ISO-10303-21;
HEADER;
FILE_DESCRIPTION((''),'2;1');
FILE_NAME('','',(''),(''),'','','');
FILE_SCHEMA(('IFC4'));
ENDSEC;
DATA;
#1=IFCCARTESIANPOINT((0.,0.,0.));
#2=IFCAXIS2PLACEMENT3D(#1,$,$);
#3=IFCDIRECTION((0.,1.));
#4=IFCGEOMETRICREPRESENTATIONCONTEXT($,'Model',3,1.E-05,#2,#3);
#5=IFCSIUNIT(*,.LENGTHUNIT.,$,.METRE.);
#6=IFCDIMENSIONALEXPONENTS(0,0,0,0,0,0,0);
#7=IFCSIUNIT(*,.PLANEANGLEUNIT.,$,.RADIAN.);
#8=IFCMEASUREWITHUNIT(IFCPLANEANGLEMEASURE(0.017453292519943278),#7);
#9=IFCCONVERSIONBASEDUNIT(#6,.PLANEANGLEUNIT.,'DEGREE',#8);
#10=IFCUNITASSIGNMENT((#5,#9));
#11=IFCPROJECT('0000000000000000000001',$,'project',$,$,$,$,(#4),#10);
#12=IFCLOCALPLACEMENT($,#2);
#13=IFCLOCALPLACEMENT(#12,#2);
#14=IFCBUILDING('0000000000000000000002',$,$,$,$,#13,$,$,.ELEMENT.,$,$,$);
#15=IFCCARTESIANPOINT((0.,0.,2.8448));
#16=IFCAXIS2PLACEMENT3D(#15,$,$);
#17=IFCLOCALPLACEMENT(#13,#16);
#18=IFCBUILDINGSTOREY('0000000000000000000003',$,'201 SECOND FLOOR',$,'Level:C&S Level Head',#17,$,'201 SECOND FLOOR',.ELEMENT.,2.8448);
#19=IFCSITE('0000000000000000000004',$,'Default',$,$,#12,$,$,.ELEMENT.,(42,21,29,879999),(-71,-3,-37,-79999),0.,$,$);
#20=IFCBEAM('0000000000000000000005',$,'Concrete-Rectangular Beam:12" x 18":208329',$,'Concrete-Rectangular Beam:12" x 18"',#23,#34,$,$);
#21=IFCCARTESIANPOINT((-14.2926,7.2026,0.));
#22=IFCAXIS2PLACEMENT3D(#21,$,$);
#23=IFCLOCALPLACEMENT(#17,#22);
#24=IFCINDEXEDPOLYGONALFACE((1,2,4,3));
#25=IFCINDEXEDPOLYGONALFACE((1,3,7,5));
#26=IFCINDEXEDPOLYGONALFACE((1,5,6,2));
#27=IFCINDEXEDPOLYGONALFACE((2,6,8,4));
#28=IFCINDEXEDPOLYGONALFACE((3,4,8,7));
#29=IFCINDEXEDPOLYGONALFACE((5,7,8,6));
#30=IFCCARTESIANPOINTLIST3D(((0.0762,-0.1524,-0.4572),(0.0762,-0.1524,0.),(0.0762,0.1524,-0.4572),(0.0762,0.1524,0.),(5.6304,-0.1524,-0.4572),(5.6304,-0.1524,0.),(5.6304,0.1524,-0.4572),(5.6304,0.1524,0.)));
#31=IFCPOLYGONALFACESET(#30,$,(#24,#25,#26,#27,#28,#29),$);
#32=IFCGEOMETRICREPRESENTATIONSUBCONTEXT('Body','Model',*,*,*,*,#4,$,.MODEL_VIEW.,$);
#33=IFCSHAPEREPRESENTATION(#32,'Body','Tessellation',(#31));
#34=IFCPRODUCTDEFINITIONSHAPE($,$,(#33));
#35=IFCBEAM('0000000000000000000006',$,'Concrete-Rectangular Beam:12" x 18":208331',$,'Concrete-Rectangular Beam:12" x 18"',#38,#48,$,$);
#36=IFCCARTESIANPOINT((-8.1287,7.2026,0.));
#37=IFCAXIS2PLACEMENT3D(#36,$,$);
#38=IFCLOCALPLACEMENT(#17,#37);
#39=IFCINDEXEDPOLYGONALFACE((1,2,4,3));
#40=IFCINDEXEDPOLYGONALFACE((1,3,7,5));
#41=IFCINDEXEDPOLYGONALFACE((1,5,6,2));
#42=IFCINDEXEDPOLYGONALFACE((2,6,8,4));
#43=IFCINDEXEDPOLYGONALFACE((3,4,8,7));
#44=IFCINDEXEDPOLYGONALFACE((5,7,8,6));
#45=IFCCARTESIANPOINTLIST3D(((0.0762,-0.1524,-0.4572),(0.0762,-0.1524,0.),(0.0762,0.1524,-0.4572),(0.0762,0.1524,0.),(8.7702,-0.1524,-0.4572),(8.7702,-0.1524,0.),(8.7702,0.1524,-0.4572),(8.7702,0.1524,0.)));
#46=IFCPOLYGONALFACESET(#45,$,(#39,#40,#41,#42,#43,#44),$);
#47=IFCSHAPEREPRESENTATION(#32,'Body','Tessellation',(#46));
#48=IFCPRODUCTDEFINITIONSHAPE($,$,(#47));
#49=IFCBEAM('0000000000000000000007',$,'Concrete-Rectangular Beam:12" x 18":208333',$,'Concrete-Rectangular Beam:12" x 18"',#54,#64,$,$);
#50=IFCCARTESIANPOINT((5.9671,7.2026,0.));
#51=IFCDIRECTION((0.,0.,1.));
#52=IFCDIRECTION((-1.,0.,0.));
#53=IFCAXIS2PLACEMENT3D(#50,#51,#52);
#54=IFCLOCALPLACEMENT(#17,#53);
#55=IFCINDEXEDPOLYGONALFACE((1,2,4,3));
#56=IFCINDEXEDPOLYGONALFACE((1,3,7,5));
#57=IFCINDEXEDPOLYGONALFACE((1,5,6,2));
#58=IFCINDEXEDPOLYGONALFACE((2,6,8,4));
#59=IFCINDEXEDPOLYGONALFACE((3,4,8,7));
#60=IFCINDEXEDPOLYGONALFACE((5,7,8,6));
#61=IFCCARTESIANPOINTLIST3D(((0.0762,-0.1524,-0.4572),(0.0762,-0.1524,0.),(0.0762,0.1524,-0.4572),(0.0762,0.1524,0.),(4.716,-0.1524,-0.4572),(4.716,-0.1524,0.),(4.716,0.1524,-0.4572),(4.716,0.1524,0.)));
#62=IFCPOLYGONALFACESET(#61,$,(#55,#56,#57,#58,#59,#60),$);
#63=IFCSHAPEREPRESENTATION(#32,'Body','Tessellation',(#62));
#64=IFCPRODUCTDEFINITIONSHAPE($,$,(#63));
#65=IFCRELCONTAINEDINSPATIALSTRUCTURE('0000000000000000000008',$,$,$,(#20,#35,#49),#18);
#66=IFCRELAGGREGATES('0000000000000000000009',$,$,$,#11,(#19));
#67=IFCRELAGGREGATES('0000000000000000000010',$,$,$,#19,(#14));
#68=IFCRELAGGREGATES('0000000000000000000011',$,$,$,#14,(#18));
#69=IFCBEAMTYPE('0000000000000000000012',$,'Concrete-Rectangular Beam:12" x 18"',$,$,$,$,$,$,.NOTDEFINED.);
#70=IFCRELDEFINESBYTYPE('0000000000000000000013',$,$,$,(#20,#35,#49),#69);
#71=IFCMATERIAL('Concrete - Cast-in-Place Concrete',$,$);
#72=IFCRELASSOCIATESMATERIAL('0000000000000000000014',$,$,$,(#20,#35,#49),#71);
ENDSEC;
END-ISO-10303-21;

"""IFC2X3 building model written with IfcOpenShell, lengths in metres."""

from ifc_helpers import new_model, entity, si_unit, converted_unit, direction, frame, frame_2d, origin, place, context, subcontext, project, spatial, rectangle, extrude, material, type_object, element, save


model = new_model("IFC2X3")

# Units and contexts
model_context = context("Model", 3, precision=1e-05, world=origin(), true_north=direction((0.0, 1.0)))
body_context = subcontext(model_context, "Body", "Model", "MODEL_VIEW")
ifc_project = project(units=[si_unit("LENGTHUNIT", "METRE"), converted_unit("PLANEANGLEUNIT", "DEGREE", entity("IfcPlaneAngleMeasure", 0.017453292519943278), si_unit("PLANEANGLEUNIT", "RADIAN"), dimensions=[0, 0, 0, 0, 0, 0, 0])], contexts=[model_context])

# Site, building, storey
site_placement = place(None, origin())
site = spatial("IfcSite", under=ifc_project, at=site_placement, Name="Default", CompositionType="ELEMENT", RefLatitude=(42, 21, 29, 879999), RefLongitude=(-71, -3, -37, -79999), RefElevation=0.0)
building_placement = place(site_placement, origin())
building = spatial("IfcBuilding", under=site, at=building_placement, CompositionType="ELEMENT")
storey_placement = place(building_placement, frame((0.0, 0.0, 2.8448)))
storey = spatial("IfcBuildingStorey", under=building, at=storey_placement, Name="201 SECOND FLOOR", ObjectType="Level:C&S Level Head", LongName="201 SECOND FLOOR", CompositionType="ELEMENT", Elevation=2.8448)

# Shared definitions
ifc_material_1 = material(Name="Concrete - Cast-in-Place Concrete")

# Beams
beam_type = type_object("IfcBeamType", Name="Concrete-Rectangular Beam:12\" x 18\"", PredefinedType="NOTDEFINED")
beam_1_placement = place(storey_placement, frame((-14.2926, 7.2026, 0.0)))
element("IfcBeam", 1, at=beam_1_placement, inside=storey, type_object=beam_type, material=ifc_material_1, Name="Concrete-Rectangular Beam:12\" x 18\":208329", ObjectType="Concrete-Rectangular Beam:12\" x 18\"", context=body_context, shape_type="SweptSolid", body=[
    extrude(rectangle(XDim=0.4572, YDim=0.3048, at=frame_2d((0.0, 0.0), x_axis=(1.0, 0.0))), frame((0.0762, 0.0, -0.2286), z_axis=(1.0, 0.0, 0.0), x_axis=(0.0, 0.0, -1.0)), (0.0, 0.0, 1.0), 5.5542),
])
beam_2_placement = place(storey_placement, frame((-8.1287, 7.2026, 0.0)))
element("IfcBeam", 2, at=beam_2_placement, inside=storey, type_object=beam_type, material=ifc_material_1, Name="Concrete-Rectangular Beam:12\" x 18\":208331", ObjectType="Concrete-Rectangular Beam:12\" x 18\"", context=body_context, shape_type="SweptSolid", body=[
    extrude(rectangle(XDim=0.4572, YDim=0.3048, at=frame_2d((0.0, 0.0), x_axis=(1.0, 0.0))), frame((0.0762, 0.0, -0.2286), z_axis=(1.0, 0.0, 0.0), x_axis=(0.0, 0.0, -1.0)), (0.0, 0.0, 1.0), 8.694),
])
beam_3_placement = place(storey_placement, frame((5.9671, 7.2026, 0.0), z_axis=(0.0, 0.0, 1.0), x_axis=(-1.0, 0.0, 0.0)))
element("IfcBeam", 3, at=beam_3_placement, inside=storey, type_object=beam_type, material=ifc_material_1, Name="Concrete-Rectangular Beam:12\" x 18\":208333", ObjectType="Concrete-Rectangular Beam:12\" x 18\"", context=body_context, shape_type="SweptSolid", body=[
    extrude(rectangle(XDim=0.4572, YDim=0.3048, at=frame_2d((0.0, 0.0), x_axis=(1.0, 0.0))), frame((0.0762, 0.0, -0.2286), z_axis=(1.0, 0.0, 0.0), x_axis=(0.0, 0.0, -1.0)), (0.0, 0.0, 1.0), 4.6398),
])

save(model, "model.ifc")
